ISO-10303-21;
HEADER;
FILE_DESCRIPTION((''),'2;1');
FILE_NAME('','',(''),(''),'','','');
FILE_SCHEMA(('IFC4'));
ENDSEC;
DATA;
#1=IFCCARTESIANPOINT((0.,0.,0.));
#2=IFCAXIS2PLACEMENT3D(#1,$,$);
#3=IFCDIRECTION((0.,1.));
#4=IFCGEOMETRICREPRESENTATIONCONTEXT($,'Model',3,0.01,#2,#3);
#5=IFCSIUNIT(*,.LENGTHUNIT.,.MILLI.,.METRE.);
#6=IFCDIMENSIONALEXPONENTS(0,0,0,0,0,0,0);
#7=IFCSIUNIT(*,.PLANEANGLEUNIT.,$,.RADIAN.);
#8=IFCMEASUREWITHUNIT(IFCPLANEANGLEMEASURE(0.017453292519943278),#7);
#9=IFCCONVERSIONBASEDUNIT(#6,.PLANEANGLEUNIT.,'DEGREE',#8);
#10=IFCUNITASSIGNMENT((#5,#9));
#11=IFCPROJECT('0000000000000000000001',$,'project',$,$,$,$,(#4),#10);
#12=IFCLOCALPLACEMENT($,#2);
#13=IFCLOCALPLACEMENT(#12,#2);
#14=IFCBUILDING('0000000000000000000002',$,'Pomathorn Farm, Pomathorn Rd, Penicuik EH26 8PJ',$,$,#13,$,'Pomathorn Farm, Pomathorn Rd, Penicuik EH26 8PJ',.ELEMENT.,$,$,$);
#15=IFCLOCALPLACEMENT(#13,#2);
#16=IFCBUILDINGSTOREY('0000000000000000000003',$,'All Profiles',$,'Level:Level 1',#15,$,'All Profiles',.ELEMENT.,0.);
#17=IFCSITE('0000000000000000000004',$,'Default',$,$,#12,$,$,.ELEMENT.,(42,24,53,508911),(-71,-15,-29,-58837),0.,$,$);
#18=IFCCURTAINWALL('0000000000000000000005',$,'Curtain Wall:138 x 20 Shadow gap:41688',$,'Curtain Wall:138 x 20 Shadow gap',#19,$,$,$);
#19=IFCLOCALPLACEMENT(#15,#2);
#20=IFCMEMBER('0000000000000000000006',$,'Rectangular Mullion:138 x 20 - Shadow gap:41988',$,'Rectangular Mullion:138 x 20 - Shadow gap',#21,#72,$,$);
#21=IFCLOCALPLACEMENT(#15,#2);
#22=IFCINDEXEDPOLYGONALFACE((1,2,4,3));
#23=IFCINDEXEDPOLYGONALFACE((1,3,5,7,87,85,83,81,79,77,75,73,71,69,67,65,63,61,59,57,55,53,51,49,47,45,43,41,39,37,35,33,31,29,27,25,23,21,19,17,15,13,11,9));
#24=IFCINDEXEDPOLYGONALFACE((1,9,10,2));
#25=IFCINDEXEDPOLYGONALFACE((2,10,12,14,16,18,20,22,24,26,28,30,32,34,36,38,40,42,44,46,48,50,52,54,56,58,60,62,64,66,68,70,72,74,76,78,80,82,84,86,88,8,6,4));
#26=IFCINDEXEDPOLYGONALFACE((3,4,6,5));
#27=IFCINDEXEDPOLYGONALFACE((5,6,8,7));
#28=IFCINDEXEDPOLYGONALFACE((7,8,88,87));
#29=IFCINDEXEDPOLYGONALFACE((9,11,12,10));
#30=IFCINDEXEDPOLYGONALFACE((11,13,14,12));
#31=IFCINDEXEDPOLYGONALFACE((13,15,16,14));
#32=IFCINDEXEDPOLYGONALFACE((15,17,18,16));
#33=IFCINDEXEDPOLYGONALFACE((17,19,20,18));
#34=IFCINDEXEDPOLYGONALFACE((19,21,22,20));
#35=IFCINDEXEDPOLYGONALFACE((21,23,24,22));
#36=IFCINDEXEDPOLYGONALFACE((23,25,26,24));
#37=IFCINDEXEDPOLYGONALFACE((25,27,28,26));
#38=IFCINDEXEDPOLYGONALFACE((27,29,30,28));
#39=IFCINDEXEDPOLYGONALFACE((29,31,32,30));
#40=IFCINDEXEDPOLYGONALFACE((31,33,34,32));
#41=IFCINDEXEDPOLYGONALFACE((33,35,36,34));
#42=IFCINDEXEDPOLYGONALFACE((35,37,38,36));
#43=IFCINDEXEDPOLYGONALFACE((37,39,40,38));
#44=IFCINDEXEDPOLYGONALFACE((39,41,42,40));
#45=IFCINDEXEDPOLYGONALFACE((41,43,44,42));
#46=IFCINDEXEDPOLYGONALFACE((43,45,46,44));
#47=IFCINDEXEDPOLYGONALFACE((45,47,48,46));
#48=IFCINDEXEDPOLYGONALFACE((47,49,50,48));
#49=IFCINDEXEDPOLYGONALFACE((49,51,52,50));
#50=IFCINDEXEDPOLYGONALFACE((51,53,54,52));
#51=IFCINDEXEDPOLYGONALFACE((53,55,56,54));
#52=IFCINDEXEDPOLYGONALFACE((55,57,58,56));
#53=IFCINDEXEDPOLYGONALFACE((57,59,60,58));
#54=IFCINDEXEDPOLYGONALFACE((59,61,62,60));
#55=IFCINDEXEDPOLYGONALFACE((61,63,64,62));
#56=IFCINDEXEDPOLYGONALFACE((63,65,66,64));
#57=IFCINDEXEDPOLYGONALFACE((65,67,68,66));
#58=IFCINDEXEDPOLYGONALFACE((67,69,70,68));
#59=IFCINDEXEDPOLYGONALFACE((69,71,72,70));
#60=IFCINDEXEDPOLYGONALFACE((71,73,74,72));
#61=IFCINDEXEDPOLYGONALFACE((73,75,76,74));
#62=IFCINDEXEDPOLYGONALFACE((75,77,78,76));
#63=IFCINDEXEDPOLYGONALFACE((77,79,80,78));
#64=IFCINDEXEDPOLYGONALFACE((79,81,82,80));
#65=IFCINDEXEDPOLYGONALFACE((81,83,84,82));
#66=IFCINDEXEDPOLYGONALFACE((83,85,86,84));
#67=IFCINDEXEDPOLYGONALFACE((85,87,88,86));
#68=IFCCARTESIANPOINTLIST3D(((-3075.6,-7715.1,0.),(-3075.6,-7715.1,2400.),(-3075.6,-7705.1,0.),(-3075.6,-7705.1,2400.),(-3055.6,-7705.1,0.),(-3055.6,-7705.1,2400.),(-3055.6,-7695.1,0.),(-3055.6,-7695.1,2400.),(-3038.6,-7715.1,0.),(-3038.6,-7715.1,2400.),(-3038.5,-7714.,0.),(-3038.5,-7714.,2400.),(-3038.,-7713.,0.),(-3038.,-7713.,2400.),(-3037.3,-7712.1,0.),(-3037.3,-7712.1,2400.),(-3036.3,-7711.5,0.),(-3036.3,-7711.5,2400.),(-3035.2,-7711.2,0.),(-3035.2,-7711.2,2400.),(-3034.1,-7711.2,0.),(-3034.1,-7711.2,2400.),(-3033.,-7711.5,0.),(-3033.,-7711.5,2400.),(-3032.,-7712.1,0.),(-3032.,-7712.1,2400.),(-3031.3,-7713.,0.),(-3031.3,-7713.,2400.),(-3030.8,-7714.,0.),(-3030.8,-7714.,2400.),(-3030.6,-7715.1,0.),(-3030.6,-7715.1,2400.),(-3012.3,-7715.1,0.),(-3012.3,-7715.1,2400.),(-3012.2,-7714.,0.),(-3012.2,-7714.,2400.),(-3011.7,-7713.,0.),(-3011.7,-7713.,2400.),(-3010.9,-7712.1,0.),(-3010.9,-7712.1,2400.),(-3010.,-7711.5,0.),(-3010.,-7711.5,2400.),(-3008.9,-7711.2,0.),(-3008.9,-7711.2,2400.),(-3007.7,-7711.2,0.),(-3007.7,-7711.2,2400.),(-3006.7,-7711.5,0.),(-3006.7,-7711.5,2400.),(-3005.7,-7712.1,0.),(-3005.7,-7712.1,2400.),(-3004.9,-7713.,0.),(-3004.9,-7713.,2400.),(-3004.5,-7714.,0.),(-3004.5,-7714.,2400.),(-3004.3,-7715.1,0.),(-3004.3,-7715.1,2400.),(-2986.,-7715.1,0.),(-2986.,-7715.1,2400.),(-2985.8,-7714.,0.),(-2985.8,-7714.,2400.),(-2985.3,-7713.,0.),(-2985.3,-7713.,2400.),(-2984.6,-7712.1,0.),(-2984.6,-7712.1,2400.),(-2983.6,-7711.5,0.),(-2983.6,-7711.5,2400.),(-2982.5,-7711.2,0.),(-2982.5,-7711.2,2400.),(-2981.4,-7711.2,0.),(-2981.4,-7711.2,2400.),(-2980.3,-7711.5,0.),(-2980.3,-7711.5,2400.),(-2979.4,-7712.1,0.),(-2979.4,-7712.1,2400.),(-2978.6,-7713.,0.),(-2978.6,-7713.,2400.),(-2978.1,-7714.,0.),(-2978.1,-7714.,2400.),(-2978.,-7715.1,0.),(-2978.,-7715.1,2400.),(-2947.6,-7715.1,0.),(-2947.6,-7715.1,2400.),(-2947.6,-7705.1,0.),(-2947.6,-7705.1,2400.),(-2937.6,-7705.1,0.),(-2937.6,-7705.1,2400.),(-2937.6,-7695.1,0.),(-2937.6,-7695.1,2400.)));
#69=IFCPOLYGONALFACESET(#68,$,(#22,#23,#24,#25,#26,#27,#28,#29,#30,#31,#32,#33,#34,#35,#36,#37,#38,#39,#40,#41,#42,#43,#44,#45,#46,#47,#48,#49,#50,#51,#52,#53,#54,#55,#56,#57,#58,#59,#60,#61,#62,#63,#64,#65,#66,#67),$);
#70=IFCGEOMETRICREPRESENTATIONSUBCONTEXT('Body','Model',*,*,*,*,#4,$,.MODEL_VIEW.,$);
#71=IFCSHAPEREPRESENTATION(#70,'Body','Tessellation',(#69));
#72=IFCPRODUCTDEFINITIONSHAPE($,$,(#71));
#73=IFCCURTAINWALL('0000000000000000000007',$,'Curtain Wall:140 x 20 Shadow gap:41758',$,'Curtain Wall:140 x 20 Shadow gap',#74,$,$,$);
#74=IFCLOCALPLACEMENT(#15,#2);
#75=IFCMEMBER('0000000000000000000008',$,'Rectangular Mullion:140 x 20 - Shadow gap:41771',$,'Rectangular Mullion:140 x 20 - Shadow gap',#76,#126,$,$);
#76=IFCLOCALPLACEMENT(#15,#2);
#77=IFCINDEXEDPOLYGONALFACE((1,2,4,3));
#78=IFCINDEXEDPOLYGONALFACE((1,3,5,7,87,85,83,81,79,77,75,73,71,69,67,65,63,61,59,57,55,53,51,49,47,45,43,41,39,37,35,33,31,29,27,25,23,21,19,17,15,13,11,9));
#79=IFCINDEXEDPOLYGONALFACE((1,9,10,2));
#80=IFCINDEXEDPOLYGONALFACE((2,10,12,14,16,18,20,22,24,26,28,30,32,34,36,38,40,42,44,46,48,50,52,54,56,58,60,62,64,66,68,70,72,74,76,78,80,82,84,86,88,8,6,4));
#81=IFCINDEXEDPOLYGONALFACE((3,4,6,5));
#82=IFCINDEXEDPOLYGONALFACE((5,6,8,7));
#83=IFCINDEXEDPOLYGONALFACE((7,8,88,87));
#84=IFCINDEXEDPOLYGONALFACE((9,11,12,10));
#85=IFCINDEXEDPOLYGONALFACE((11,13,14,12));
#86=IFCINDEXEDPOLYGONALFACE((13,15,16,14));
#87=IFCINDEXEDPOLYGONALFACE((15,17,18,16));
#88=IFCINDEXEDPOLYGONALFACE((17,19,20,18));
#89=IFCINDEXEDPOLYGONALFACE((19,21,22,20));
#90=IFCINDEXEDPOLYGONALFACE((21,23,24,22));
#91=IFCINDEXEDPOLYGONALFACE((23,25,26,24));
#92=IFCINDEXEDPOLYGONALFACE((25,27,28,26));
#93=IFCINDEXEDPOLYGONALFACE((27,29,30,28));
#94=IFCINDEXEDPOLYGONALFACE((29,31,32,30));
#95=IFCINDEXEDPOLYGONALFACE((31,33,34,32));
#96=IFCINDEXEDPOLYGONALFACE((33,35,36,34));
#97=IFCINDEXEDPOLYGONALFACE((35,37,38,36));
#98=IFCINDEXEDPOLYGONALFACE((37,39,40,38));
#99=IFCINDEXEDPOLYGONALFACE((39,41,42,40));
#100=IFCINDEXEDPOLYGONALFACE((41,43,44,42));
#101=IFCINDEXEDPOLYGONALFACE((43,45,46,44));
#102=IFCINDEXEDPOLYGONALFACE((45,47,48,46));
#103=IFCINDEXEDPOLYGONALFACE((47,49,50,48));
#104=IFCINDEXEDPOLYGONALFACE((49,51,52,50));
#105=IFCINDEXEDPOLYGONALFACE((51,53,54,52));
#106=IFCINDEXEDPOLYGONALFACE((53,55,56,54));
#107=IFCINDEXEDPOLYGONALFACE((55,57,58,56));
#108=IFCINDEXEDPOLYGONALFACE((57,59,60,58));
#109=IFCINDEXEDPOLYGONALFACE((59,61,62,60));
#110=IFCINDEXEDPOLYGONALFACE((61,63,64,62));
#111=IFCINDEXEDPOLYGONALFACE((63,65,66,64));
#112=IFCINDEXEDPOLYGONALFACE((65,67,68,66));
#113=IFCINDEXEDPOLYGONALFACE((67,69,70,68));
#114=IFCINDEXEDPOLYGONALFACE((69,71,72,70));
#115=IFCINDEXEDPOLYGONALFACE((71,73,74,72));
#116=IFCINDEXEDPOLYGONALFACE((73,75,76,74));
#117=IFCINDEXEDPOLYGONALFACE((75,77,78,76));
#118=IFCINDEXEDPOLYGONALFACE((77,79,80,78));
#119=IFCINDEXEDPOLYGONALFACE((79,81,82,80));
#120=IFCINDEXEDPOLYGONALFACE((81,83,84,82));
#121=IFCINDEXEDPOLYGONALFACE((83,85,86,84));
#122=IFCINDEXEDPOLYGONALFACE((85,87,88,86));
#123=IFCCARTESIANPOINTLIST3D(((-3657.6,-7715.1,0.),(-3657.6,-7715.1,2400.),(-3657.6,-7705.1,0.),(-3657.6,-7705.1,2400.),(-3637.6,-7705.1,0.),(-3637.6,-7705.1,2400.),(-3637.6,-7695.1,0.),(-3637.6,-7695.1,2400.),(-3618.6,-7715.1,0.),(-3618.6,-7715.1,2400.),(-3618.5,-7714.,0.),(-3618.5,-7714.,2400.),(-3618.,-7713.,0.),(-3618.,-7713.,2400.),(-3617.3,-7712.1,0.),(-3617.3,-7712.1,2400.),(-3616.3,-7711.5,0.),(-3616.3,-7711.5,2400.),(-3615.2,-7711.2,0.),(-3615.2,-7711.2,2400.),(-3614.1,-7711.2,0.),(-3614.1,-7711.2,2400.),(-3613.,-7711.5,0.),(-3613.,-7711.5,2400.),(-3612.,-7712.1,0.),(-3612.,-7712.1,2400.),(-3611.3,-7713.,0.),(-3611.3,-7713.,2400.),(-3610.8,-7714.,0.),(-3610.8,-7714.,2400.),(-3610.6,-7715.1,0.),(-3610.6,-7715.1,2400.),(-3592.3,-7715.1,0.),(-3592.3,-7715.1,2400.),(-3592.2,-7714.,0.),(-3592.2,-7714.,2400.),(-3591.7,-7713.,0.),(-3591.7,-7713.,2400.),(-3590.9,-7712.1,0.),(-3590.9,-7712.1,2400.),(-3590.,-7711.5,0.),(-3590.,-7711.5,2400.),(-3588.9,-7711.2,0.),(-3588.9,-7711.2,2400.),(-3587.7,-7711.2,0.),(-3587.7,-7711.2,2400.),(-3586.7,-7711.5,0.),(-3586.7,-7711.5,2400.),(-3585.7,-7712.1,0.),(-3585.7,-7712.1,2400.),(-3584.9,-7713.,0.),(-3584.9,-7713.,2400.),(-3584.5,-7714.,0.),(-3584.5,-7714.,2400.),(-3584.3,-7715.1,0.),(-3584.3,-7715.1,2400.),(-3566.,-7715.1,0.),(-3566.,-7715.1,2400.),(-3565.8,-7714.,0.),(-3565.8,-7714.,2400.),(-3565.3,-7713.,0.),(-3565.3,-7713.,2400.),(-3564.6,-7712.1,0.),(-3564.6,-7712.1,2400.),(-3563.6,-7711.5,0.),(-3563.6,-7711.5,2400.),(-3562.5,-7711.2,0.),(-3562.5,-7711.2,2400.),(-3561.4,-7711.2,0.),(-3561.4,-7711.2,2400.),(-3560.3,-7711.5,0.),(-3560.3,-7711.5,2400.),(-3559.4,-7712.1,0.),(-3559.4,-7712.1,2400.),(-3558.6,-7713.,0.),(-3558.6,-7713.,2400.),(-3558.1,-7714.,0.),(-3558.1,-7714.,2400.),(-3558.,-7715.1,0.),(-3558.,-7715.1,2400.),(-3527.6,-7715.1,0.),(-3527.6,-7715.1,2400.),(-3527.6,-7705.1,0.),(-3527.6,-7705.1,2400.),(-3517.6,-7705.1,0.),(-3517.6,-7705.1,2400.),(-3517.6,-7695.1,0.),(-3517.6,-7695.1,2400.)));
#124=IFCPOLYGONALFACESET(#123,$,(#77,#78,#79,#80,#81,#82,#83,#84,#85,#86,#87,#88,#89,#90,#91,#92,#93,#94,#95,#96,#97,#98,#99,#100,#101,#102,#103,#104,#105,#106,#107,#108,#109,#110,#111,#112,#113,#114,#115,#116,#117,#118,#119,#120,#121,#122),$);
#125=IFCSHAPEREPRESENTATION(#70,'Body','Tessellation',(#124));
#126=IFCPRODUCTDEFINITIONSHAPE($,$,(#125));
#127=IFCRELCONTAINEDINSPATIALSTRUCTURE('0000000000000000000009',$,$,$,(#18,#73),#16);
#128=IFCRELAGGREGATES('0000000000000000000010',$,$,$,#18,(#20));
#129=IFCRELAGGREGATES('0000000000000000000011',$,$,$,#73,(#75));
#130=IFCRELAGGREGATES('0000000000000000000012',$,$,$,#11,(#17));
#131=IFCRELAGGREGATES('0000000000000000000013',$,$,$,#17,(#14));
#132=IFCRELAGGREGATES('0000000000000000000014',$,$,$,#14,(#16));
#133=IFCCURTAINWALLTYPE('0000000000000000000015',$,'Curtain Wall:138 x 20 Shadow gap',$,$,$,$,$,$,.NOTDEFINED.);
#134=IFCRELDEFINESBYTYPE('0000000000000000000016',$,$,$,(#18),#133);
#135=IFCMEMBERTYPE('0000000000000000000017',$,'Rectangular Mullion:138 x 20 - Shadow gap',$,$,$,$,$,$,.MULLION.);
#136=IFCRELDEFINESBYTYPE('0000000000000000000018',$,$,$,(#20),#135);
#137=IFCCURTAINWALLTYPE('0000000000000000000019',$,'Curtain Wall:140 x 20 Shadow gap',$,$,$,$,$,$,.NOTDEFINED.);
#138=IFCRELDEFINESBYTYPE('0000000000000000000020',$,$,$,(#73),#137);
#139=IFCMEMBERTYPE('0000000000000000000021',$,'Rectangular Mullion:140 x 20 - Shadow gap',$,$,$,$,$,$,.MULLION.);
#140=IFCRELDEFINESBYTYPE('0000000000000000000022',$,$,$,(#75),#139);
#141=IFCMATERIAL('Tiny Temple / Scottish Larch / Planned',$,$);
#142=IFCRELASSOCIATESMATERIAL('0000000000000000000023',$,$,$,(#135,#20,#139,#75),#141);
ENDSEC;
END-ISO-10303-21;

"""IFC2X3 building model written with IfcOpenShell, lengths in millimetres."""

from ifc_helpers import new_model, entity, si_unit, converted_unit, direction, frame, frame_2d, origin, place, context, subcontext, project, spatial, polyline, circle_curve, parameter, trimmed, segment, composite_curve, outline, extrude, source, transform, mapped, material, type_object, type_shapes, element, aggregate, save


model = new_model("IFC2X3")

# Units and contexts
model_context = context("Model", 3, precision=0.01, world=origin(), true_north=direction((0.0, 1.0)))
body_context = subcontext(model_context, "Body", "Model", "MODEL_VIEW")
ifc_project = project(units=[si_unit("LENGTHUNIT", "METRE", prefix="MILLI"), converted_unit("PLANEANGLEUNIT", "DEGREE", entity("IfcPlaneAngleMeasure", 0.017453292519943278), si_unit("PLANEANGLEUNIT", "RADIAN"), dimensions=[0, 0, 0, 0, 0, 0, 0])], contexts=[model_context])

# Site, building, storey
site_placement = place(None, origin())
site = spatial("IfcSite", under=ifc_project, at=site_placement, Name="Default", CompositionType="ELEMENT", RefLatitude=(42, 24, 53, 508911), RefLongitude=(-71, -15, -29, -58837), RefElevation=0.0)
building_placement = place(site_placement, origin())
building = spatial("IfcBuilding", under=site, at=building_placement, Name="Pomathorn Farm, Pomathorn Rd, Penicuik EH26 8PJ", LongName="Pomathorn Farm, Pomathorn Rd, Penicuik EH26 8PJ", CompositionType="ELEMENT")
storey_placement = place(building_placement, origin())
storey = spatial("IfcBuildingStorey", under=building, at=storey_placement, Name="All Profiles", ObjectType="Level:Level 1", LongName="All Profiles", CompositionType="ELEMENT", Elevation=0.0)

# Curtain walls, members
curtain_wall_type_1 = type_object("IfcCurtainWallType", Name="Curtain Wall:138 x 20 Shadow gap", PredefinedType="NOTDEFINED")
curtain_wall_1_placement = place(storey_placement, origin())
curtain_wall_1 = element("IfcCurtainWall", 1, at=curtain_wall_1_placement, inside=storey, type_object=curtain_wall_type_1, Name="Curtain Wall:138 x 20 Shadow gap:41688", ObjectType="Curtain Wall:138 x 20 Shadow gap")
ifc_material = material(Name="Tiny Temple / Scottish Larch / Planned")
member_type_1 = type_object("IfcMemberType", Name="Rectangular Mullion:138 x 20 - Shadow gap", PredefinedType="MULLION", material=ifc_material)
shared_shape_1 = source(origin(), body_context, "Body", "SweptSolid", [
    extrude(outline(composite_curve([segment(polyline([(27.9, -5.7), (58.3, -5.7)]), True, "CONTINUOUS"), segment(polyline([(58.3, -5.7), (58.3, 4.3)]), True, "CONTINUOUS"), segment(polyline([(58.3, 4.3), (68.3, 4.3)]), True, "CONTINUOUS"), segment(polyline([(68.3, 4.3), (68.3, 14.3)]), True, "CONTINUOUS"), segment(polyline([(68.3, 14.3), (-49.7, 14.3)]), True, "CONTINUOUS"), segment(polyline([(-49.7, 14.3), (-49.7, 4.3)]), True, "CONTINUOUS"), segment(polyline([(-49.7, 4.3), (-69.7, 4.3)]), True, "CONTINUOUS"), segment(polyline([(-69.7, 4.3), (-69.7, -5.7)]), True, "CONTINUOUS"), segment(polyline([(-69.7, -5.7), (-32.7, -5.7)]), True, "CONTINUOUS"), segment(trimmed(circle_curve(frame_2d((-28.7, -5.7), x_axis=(1.0, 0.0)), 4.0), [parameter(360.0)], [parameter(180.0)], True, "PARAMETER"), False, "CONTINUOUS"), segment(polyline([(-24.7, -5.7), (-6.4, -5.7)]), True, "CONTINUOUS"), segment(trimmed(circle_curve(frame_2d((-2.4, -5.7), x_axis=(1.0, 0.0)), 4.0), [parameter(360.0)], [parameter(180.0)], True, "PARAMETER"), False, "CONTINUOUS"), segment(polyline([(1.6, -5.7), (19.9, -5.7)]), True, "CONTINUOUS"), segment(trimmed(circle_curve(frame_2d((23.9, -5.7), x_axis=(1.0, 0.0)), 4.0), [parameter(360.0)], [parameter(180.0)], True, "PARAMETER"), False, "CONTINUOUS")], self_intersect=False)), frame((-68.3, -5.7, -2400.0), z_axis=(0.0, 0.0, -1.0), x_axis=(1.0, 0.0, 0.0)), (0.0, 0.0, -1.0), 2400.0),
])
type_shapes(member_type_1, [shared_shape_1])
member_1_placement = place(curtain_wall_1_placement, frame((-2937.6, -7715.1, 0.0), z_axis=(0.0, 0.0, -1.0), x_axis=(1.0, 0.0, 0.0)))
member_1 = element("IfcMember", 2, at=member_1_placement, type_object=member_type_1, material=ifc_material, Name="Rectangular Mullion:138 x 20 - Shadow gap:41988", ObjectType="Rectangular Mullion:138 x 20 - Shadow gap", context=body_context, shape_type="MappedRepresentation", body=[
    mapped(shared_shape_1, transform((0.0, 0.0, 0.0), scale=1.0)),
])
aggregate(curtain_wall_1, [member_1])
curtain_wall_type_2 = type_object("IfcCurtainWallType", Name="Curtain Wall:140 x 20 Shadow gap", PredefinedType="NOTDEFINED")
curtain_wall_2_placement = place(storey_placement, origin())
curtain_wall_2 = element("IfcCurtainWall", 3, at=curtain_wall_2_placement, inside=storey, type_object=curtain_wall_type_2, Name="Curtain Wall:140 x 20 Shadow gap:41758", ObjectType="Curtain Wall:140 x 20 Shadow gap")
member_type_2 = type_object("IfcMemberType", Name="Rectangular Mullion:140 x 20 - Shadow gap", PredefinedType="MULLION", material=ifc_material)
shared_shape_2 = source(origin(), body_context, "Body", "SweptSolid", [
    extrude(outline(composite_curve([segment(polyline([(28.5, -5.7), (58.9, -5.7)]), True, "CONTINUOUS"), segment(polyline([(58.9, -5.7), (58.9, 4.3)]), True, "CONTINUOUS"), segment(polyline([(58.9, 4.3), (68.9, 4.3)]), True, "CONTINUOUS"), segment(polyline([(68.9, 4.3), (68.9, 14.3)]), True, "CONTINUOUS"), segment(polyline([(68.9, 14.3), (-51.1, 14.3)]), True, "CONTINUOUS"), segment(polyline([(-51.1, 14.3), (-51.1, 4.3)]), True, "CONTINUOUS"), segment(polyline([(-51.1, 4.3), (-71.1, 4.3)]), True, "CONTINUOUS"), segment(polyline([(-71.1, 4.3), (-71.1, -5.7)]), True, "CONTINUOUS"), segment(polyline([(-71.1, -5.7), (-32.1, -5.7)]), True, "CONTINUOUS"), segment(trimmed(circle_curve(frame_2d((-28.1, -5.7), x_axis=(1.0, 0.0)), 4.0), [parameter(360.0)], [parameter(180.0)], True, "PARAMETER"), False, "CONTINUOUS"), segment(polyline([(-24.1, -5.7), (-5.8, -5.7)]), True, "CONTINUOUS"), segment(trimmed(circle_curve(frame_2d((-1.8, -5.7), x_axis=(1.0, 0.0)), 4.0), [parameter(360.0)], [parameter(180.0)], True, "PARAMETER"), False, "CONTINUOUS"), segment(polyline([(2.2, -5.7), (20.5, -5.7)]), True, "CONTINUOUS"), segment(trimmed(circle_curve(frame_2d((24.5, -5.7), x_axis=(1.0, 0.0)), 4.0), [parameter(360.0)], [parameter(180.0)], True, "PARAMETER"), False, "CONTINUOUS")], self_intersect=False)), frame((-68.9, -5.7, -2400.0), z_axis=(0.0, 0.0, -1.0), x_axis=(1.0, 0.0, 0.0)), (0.0, 0.0, -1.0), 2400.0),
])
type_shapes(member_type_2, [shared_shape_2])
member_2_placement = place(curtain_wall_2_placement, frame((-3517.6, -7715.1, 0.0), z_axis=(0.0, 0.0, -1.0), x_axis=(1.0, 0.0, 0.0)))
member_2 = element("IfcMember", 4, at=member_2_placement, type_object=member_type_2, material=ifc_material, Name="Rectangular Mullion:140 x 20 - Shadow gap:41771", ObjectType="Rectangular Mullion:140 x 20 - Shadow gap", context=body_context, shape_type="MappedRepresentation", body=[
    mapped(shared_shape_2, transform((0.0, 0.0, 0.0), scale=1.0)),
])
aggregate(curtain_wall_2, [member_2])

save(model, "model.ifc")
